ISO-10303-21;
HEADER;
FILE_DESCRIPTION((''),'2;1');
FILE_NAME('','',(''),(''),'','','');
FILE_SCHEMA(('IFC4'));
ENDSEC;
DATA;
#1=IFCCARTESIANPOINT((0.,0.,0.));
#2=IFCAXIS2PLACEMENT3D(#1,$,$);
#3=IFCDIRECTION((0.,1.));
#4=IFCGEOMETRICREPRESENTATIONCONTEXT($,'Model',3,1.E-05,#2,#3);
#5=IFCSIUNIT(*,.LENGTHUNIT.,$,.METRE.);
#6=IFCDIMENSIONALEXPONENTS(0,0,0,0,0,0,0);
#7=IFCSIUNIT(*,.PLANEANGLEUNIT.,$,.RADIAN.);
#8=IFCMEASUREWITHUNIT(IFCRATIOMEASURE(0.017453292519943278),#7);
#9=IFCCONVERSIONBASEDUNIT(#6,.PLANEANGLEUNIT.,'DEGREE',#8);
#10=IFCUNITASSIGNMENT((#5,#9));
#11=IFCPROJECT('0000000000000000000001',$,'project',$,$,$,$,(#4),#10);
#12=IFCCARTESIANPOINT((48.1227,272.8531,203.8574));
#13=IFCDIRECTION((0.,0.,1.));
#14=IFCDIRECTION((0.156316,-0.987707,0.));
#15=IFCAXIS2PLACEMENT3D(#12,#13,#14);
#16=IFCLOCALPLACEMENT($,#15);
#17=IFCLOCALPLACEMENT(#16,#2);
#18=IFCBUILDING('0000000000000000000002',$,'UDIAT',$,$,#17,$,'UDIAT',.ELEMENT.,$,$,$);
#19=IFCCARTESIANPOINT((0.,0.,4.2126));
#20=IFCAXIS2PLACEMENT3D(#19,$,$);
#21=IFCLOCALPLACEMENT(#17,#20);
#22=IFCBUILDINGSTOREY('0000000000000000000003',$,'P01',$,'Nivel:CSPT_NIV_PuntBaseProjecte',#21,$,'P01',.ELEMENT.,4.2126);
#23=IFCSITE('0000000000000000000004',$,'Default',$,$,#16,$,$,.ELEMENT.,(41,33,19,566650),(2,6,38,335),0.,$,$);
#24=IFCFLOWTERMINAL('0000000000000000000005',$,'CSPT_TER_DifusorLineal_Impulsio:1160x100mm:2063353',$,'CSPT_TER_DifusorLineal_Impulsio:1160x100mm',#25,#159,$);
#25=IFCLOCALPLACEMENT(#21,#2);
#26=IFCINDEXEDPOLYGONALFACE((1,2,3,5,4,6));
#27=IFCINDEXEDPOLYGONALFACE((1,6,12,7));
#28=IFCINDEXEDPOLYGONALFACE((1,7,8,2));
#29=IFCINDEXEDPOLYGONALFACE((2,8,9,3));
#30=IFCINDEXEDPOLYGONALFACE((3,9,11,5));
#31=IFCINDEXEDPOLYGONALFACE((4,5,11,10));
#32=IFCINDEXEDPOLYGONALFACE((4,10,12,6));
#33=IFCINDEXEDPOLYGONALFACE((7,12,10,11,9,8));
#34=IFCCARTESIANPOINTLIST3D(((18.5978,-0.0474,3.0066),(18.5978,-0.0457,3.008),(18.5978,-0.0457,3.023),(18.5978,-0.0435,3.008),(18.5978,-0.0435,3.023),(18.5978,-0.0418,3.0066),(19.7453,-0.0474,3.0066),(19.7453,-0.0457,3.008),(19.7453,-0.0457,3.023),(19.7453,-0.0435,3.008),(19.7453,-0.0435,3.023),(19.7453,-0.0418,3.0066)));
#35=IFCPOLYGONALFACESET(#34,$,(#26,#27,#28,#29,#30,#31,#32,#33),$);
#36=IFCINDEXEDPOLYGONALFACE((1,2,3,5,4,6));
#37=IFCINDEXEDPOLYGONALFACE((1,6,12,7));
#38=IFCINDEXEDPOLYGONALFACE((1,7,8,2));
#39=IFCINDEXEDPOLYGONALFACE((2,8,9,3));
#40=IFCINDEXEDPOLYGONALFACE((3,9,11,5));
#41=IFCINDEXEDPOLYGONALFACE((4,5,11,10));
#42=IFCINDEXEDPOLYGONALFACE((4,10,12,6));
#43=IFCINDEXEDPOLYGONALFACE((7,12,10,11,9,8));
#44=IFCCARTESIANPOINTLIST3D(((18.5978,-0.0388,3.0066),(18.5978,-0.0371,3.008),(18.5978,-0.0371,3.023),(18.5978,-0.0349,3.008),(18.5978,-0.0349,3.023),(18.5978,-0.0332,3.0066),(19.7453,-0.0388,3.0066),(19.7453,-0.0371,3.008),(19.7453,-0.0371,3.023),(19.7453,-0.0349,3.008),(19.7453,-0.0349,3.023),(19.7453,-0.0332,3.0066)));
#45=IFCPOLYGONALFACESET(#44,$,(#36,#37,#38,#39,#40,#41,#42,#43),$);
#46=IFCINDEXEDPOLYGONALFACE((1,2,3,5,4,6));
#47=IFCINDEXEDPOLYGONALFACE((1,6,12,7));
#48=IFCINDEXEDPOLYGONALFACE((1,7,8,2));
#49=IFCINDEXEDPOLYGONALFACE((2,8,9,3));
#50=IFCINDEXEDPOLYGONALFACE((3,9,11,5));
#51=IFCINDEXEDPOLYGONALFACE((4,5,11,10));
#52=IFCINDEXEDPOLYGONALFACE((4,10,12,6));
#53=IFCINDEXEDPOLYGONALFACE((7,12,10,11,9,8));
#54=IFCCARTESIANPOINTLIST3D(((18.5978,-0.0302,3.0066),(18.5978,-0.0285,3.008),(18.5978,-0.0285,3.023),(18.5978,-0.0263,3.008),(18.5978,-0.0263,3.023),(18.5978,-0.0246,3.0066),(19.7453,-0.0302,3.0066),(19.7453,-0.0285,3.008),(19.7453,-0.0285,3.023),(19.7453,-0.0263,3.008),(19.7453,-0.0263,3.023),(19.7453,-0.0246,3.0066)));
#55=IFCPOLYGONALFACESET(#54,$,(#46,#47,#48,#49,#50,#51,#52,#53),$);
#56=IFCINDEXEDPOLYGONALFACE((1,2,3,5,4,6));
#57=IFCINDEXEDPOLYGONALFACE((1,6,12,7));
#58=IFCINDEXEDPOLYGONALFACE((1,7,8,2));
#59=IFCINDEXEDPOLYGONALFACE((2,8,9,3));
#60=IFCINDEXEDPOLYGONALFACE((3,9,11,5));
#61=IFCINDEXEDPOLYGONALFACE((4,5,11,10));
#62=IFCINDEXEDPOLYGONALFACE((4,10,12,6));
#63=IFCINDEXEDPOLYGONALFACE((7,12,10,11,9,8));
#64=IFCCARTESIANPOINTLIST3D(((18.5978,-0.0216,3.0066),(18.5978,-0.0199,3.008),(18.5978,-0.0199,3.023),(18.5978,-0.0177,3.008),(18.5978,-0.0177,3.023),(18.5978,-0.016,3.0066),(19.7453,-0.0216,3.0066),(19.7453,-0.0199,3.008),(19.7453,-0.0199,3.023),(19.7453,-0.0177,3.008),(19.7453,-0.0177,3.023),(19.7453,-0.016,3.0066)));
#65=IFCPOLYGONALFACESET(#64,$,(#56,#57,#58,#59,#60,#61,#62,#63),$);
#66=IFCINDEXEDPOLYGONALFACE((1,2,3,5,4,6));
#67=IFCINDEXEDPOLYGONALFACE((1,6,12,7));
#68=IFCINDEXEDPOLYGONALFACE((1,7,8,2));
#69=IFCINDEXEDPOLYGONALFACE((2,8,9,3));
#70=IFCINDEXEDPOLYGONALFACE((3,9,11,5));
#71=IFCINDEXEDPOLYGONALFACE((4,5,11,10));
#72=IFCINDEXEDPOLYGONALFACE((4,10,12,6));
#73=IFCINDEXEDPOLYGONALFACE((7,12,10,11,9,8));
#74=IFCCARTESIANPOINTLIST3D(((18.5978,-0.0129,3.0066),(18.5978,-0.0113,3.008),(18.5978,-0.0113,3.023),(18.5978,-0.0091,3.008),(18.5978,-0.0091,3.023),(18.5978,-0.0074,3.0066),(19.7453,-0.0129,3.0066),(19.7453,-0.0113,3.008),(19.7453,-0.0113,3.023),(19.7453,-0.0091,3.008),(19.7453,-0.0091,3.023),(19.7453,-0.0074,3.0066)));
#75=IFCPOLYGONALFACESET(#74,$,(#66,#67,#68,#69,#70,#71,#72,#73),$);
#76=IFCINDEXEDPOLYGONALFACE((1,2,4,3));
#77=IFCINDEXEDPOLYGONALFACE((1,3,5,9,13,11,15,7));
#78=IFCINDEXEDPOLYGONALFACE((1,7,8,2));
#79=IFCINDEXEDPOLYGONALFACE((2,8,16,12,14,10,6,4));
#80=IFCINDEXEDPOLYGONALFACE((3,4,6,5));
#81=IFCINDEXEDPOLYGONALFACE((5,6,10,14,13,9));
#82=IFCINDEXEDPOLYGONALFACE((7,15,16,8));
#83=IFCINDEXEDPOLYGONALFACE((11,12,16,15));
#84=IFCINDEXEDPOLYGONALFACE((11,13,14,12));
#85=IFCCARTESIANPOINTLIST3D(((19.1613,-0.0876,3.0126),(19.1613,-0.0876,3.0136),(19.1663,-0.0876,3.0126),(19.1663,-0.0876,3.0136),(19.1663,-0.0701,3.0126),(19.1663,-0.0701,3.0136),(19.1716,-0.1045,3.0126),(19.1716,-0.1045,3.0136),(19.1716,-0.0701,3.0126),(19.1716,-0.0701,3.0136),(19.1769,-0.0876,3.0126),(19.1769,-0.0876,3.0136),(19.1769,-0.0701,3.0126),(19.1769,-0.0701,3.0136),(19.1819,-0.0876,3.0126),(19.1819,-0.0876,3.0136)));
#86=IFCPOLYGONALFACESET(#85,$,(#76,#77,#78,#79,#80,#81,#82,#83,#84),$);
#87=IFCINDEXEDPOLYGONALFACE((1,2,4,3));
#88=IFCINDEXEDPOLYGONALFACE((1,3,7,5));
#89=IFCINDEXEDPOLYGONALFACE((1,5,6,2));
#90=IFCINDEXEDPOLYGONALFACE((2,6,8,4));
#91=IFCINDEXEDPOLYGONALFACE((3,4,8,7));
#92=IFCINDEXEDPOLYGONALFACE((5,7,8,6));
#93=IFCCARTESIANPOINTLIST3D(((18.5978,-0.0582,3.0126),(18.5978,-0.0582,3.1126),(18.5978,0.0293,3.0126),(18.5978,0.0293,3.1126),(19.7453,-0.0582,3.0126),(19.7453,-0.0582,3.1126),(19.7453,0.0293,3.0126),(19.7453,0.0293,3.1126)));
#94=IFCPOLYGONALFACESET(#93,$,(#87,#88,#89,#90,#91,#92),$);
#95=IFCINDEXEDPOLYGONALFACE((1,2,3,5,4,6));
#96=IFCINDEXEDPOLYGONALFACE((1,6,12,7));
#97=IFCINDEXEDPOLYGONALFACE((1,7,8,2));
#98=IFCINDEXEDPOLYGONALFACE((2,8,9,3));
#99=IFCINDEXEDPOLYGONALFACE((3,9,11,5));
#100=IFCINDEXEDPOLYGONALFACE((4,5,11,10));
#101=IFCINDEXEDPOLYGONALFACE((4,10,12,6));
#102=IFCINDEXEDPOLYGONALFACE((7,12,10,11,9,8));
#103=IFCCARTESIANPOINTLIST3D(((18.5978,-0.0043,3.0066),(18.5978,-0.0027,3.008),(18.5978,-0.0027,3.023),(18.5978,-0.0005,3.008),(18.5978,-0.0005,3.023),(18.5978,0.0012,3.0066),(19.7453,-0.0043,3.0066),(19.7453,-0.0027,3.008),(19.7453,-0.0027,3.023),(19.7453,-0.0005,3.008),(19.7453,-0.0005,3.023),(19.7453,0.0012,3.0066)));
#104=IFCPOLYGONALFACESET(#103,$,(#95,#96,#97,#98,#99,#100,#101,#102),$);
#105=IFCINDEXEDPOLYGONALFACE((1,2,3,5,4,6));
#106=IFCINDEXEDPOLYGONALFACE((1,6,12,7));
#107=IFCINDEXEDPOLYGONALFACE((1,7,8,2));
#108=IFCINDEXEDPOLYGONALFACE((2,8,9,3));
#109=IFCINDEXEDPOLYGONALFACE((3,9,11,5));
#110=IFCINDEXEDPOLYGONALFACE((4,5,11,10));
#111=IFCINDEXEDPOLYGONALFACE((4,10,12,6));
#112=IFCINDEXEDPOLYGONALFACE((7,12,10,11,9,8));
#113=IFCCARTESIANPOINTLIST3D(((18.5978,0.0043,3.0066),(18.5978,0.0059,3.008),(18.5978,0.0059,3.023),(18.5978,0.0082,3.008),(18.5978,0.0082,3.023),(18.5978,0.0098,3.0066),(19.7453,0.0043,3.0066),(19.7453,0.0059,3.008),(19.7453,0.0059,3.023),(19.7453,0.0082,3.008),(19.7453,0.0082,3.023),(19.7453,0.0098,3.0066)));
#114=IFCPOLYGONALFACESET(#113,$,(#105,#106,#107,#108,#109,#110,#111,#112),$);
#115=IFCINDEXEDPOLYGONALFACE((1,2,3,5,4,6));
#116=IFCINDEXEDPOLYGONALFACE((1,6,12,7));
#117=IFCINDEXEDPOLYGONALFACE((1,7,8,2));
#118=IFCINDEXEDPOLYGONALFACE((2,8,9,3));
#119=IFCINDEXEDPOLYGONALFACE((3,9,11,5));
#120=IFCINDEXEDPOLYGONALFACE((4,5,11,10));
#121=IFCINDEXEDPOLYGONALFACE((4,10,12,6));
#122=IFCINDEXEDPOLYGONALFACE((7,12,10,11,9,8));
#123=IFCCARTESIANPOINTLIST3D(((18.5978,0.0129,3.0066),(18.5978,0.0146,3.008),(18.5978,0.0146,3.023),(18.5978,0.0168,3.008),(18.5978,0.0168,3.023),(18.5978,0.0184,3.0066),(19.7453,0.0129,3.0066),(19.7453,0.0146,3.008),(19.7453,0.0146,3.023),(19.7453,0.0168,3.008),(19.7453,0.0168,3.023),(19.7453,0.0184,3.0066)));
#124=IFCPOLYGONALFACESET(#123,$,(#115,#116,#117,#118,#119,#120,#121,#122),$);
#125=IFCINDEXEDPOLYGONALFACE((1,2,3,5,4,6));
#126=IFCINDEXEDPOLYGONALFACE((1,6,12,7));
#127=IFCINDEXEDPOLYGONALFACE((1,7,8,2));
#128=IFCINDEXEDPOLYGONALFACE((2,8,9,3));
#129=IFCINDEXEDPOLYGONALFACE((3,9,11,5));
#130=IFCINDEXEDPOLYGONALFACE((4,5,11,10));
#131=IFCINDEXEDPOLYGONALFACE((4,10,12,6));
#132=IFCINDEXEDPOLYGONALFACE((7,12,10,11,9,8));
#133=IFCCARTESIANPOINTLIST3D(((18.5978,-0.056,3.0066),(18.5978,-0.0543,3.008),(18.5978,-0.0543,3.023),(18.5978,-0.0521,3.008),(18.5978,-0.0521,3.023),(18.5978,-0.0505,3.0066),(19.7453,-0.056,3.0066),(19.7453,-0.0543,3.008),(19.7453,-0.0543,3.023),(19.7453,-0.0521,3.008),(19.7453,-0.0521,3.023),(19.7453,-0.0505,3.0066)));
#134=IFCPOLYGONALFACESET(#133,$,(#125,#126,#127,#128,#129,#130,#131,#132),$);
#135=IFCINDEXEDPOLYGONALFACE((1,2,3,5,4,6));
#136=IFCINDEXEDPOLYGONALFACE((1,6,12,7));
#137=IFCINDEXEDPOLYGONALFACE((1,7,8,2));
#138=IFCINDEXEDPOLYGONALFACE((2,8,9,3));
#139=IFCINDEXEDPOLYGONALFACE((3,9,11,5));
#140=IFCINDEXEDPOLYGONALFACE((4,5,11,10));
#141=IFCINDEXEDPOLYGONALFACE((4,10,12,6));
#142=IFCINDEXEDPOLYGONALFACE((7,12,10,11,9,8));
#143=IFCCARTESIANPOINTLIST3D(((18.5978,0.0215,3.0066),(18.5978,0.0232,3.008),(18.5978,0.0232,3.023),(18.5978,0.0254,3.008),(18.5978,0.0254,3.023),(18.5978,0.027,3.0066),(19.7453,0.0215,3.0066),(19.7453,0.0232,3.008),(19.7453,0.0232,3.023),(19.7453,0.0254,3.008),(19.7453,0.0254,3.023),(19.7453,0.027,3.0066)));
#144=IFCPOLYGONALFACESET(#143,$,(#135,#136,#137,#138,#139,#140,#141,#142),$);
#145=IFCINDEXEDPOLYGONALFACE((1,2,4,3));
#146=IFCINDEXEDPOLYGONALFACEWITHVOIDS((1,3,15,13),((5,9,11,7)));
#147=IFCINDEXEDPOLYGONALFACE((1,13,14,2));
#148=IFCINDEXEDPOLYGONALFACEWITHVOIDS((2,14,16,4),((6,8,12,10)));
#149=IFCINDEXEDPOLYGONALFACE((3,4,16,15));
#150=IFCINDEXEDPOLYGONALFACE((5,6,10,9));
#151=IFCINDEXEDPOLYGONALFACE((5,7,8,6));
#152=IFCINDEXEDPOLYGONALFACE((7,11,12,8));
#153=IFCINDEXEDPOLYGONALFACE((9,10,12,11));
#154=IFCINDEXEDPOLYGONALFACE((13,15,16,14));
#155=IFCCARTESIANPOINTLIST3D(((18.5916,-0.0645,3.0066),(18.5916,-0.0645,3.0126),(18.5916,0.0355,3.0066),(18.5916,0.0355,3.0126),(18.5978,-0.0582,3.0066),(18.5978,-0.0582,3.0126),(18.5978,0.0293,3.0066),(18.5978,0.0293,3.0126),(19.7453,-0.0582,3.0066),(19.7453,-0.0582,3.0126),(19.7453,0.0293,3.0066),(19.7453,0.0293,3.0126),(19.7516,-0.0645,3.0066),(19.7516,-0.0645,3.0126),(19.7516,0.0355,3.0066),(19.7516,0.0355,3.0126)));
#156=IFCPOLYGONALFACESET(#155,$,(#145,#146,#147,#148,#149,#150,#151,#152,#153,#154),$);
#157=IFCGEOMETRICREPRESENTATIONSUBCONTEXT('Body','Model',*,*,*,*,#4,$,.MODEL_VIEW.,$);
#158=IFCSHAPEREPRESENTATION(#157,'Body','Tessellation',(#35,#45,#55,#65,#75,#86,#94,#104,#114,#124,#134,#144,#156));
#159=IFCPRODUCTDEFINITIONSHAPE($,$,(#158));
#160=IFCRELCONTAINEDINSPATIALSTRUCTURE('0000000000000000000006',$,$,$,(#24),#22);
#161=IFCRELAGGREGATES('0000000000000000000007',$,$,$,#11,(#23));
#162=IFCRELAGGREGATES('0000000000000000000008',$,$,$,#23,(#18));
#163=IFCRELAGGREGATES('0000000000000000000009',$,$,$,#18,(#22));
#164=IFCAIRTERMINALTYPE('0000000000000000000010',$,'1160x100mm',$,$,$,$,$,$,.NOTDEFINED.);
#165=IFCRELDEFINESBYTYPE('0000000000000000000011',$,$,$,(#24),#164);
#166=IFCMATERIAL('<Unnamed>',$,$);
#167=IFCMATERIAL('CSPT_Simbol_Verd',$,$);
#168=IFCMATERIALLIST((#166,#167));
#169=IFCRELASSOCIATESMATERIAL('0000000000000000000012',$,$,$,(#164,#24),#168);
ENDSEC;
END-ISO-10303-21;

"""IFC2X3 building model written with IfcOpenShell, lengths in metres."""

from ifc_helpers import new_model, entity, si_unit, converted_unit, direction, frame, origin, origin_2d_with_axis, place, context, subcontext, project, spatial, polyline, rectangle, outline, extrude, source, transform, mapped, material, material_list, type_object, type_shapes, element, save


model = new_model("IFC2X3")

# Units and contexts
model_context = context("Model", 3, precision=1e-05, world=origin(), true_north=direction((0.0, 1.0)))
body_context = subcontext(model_context, "Body", "Model", "MODEL_VIEW")
ifc_project = project(units=[si_unit("LENGTHUNIT", "METRE"), converted_unit("PLANEANGLEUNIT", "DEGREE", entity("IfcRatioMeasure", 0.017453292519943278), si_unit("PLANEANGLEUNIT", "RADIAN"), dimensions=[0, 0, 0, 0, 0, 0, 0])], contexts=[model_context])

# Site, building, storey
site_placement = place(None, frame((48.1227, 272.8531, 203.8574), z_axis=(0.0, 0.0, 1.0), x_axis=(0.156316, -0.987707, 0.0)))
site = spatial("IfcSite", under=ifc_project, at=site_placement, Name="Default", CompositionType="ELEMENT", RefLatitude=(41, 33, 19, 566650), RefLongitude=(2, 6, 38, 335), RefElevation=0.0)
building_placement = place(site_placement, origin())
building = spatial("IfcBuilding", under=site, at=building_placement, Name="UDIAT", LongName="UDIAT", CompositionType="ELEMENT")
storey_placement = place(building_placement, frame((0.0, 0.0, 4.2126)))
storey = spatial("IfcBuildingStorey", under=building, at=storey_placement, Name="P01", ObjectType="Nivel:CSPT_NIV_PuntBaseProjecte", LongName="P01", CompositionType="ELEMENT", Elevation=4.2126)

# Shared definitions
ifc_material_1 = material(Name="<Unnamed>")

# Flow terminal
ifc_material_2 = material(Name="CSPT_Simbol_Verd")
ifc_material_list = material_list([ifc_material_1, ifc_material_2])
air_terminal_type = type_object("IfcAirTerminalType", Name="1160x100mm", PredefinedType="NOTDEFINED", material=ifc_material_list)
shared_shape_1 = source(origin(), body_context, "Body", "SweptSolid", [
    extrude(outline(polyline([(0.0037, 0.0028), (0.0059, 0.0028), (0.0016, 0.0063), (0.002, 0.0042), (-0.0074, -0.0074), (-0.0057, -0.0088), (0.0037, 0.0028)])), frame((-0.5737, 0.0301, -0.0001), z_axis=(1.0, 0.0, 0.0), x_axis=(0.0, -0.776119, -0.630587)), (0.0, 0.0, 1.0), 1.1475),
    extrude(outline(polyline([(0.0037, 0.0028), (0.0059, 0.0028), (0.0016, 0.0063), (0.002, 0.0042), (-0.0074, -0.0074), (-0.0057, -0.0088), (0.0037, 0.0028)])), frame((-0.5737, 0.0215, -0.0001), z_axis=(1.0, 0.0, 0.0), x_axis=(0.0, -0.776119, -0.630587)), (0.0, 0.0, 1.0), 1.1475),
    extrude(outline(polyline([(0.0037, 0.0028), (0.0059, 0.0028), (0.0016, 0.0063), (0.002, 0.0042), (-0.0074, -0.0074), (-0.0057, -0.0088), (0.0037, 0.0028)])), frame((-0.5737, 0.0129, -0.0001), z_axis=(1.0, 0.0, 0.0), x_axis=(0.0, -0.776119, -0.630587)), (0.0, 0.0, 1.0), 1.1475),
    extrude(outline(polyline([(0.0037, 0.0028), (0.0059, 0.0028), (0.0016, 0.0063), (0.002, 0.0042), (-0.0074, -0.0074), (-0.0057, -0.0088), (0.0037, 0.0028)])), frame((-0.5737, 0.0043, -0.0001), z_axis=(1.0, 0.0, 0.0), x_axis=(0.0, -0.776119, -0.630587)), (0.0, 0.0, 1.0), 1.1475),
    extrude(outline(polyline([(0.0037, 0.0028), (0.0059, 0.0028), (0.0016, 0.0063), (0.002, 0.0042), (-0.0074, -0.0074), (-0.0057, -0.0088), (0.0037, 0.0028)])), frame((-0.5737, -0.0043, -0.0001), z_axis=(1.0, 0.0, 0.0), x_axis=(0.0, -0.776119, -0.630587)), (0.0, 0.0, 1.0), 1.1475),
    extrude(outline(polyline([(0.0, -0.013), (0.0053, -0.013), (0.0053, 0.0045), (0.0103, 0.0045), (0.0, 0.0213), (-0.0103, 0.0045), (-0.0053, 0.0045), (-0.0053, -0.013), (0.0, -0.013)])), frame((0.0, 0.0687, 0.0)), (0.0, 0.0, 1.0), 0.001),
    extrude(rectangle(XDim=1.1475, YDim=0.0875, at=origin_2d_with_axis()), frame((0.0, 0.0, 0.0), z_axis=(0.0, 0.0, 1.0), x_axis=(-1.0, 0.0, 0.0)), (0.0, 0.0, 1.0), 0.1),
    extrude(outline(polyline([(0.0037, 0.0028), (0.0059, 0.0028), (0.0016, 0.0063), (0.002, 0.0042), (-0.0074, -0.0074), (-0.0057, -0.0088), (0.0037, 0.0028)])), frame((-0.5737, -0.0129, -0.0001), z_axis=(1.0, 0.0, 0.0), x_axis=(0.0, -0.776119, -0.630587)), (0.0, 0.0, 1.0), 1.1475),
    extrude(outline(polyline([(0.0037, 0.0028), (0.0059, 0.0028), (0.0016, 0.0063), (0.002, 0.0042), (-0.0074, -0.0074), (-0.0057, -0.0088), (0.0037, 0.0028)])), frame((-0.5737, -0.0215, -0.0001), z_axis=(1.0, 0.0, 0.0), x_axis=(0.0, -0.776119, -0.630587)), (0.0, 0.0, 1.0), 1.1475),
    extrude(outline(polyline([(0.0037, 0.0028), (0.0059, 0.0028), (0.0016, 0.0063), (0.002, 0.0042), (-0.0074, -0.0074), (-0.0057, -0.0088), (0.0037, 0.0028)])), frame((-0.5737, -0.0301, -0.0001), z_axis=(1.0, 0.0, 0.0), x_axis=(0.0, -0.776119, -0.630587)), (0.0, 0.0, 1.0), 1.1475),
    extrude(outline(polyline([(0.0037, 0.0028), (0.0059, 0.0028), (0.0016, 0.0063), (0.002, 0.0042), (-0.0074, -0.0074), (-0.0057, -0.0088), (0.0037, 0.0028)])), frame((-0.5737, 0.0388, -0.0001), z_axis=(1.0, 0.0, 0.0), x_axis=(0.0, -0.776119, -0.630587)), (0.0, 0.0, 1.0), 1.1475),
    extrude(outline(polyline([(0.0037, 0.0028), (0.0059, 0.0028), (0.0016, 0.0063), (0.002, 0.0042), (-0.0074, -0.0074), (-0.0057, -0.0088), (0.0037, 0.0028)])), frame((-0.5737, -0.0387, -0.0001), z_axis=(1.0, 0.0, 0.0), x_axis=(0.0, -0.776119, -0.630587)), (0.0, 0.0, 1.0), 1.1475),
    extrude(outline(polyline([(-0.58, -0.05), (0.58, -0.05), (0.58, 0.05), (-0.58, 0.05), (-0.58, -0.05)]), holes=[polyline([(-0.5738, -0.0438), (-0.5738, 0.0437), (0.5737, 0.0437), (0.5737, -0.0438), (-0.5738, -0.0438)])]), frame((0.0, 0.0, -0.006), z_axis=(0.0, 0.0, 1.0), x_axis=(-1.0, 0.0, 0.0)), (0.0, 0.0, 1.0), 0.006),
])
type_shapes(air_terminal_type, [shared_shape_1])
for number, where, z_axis, x_axis, name in (
    (1, (19.1716, -0.0145, 3.0126), (0.0, 0.0, 1.0), (-1.0, 0.0, 0.0), "CSPT_TER_DifusorLineal_Impulsio:1160x100mm:2063353"),
):
    element("IfcFlowTerminal", number, at=place(storey_placement, frame(where, z_axis=z_axis, x_axis=x_axis)), inside=storey, type_object=air_terminal_type, material=ifc_material_list, Name=name, ObjectType="CSPT_TER_DifusorLineal_Impulsio:1160x100mm", context=body_context, shape_type="MappedRepresentation", body=[
        mapped(shared_shape_1, transform((0.0, 0.0, 0.0), scale=1.0)),
    ])

save(model, "model.ifc")
